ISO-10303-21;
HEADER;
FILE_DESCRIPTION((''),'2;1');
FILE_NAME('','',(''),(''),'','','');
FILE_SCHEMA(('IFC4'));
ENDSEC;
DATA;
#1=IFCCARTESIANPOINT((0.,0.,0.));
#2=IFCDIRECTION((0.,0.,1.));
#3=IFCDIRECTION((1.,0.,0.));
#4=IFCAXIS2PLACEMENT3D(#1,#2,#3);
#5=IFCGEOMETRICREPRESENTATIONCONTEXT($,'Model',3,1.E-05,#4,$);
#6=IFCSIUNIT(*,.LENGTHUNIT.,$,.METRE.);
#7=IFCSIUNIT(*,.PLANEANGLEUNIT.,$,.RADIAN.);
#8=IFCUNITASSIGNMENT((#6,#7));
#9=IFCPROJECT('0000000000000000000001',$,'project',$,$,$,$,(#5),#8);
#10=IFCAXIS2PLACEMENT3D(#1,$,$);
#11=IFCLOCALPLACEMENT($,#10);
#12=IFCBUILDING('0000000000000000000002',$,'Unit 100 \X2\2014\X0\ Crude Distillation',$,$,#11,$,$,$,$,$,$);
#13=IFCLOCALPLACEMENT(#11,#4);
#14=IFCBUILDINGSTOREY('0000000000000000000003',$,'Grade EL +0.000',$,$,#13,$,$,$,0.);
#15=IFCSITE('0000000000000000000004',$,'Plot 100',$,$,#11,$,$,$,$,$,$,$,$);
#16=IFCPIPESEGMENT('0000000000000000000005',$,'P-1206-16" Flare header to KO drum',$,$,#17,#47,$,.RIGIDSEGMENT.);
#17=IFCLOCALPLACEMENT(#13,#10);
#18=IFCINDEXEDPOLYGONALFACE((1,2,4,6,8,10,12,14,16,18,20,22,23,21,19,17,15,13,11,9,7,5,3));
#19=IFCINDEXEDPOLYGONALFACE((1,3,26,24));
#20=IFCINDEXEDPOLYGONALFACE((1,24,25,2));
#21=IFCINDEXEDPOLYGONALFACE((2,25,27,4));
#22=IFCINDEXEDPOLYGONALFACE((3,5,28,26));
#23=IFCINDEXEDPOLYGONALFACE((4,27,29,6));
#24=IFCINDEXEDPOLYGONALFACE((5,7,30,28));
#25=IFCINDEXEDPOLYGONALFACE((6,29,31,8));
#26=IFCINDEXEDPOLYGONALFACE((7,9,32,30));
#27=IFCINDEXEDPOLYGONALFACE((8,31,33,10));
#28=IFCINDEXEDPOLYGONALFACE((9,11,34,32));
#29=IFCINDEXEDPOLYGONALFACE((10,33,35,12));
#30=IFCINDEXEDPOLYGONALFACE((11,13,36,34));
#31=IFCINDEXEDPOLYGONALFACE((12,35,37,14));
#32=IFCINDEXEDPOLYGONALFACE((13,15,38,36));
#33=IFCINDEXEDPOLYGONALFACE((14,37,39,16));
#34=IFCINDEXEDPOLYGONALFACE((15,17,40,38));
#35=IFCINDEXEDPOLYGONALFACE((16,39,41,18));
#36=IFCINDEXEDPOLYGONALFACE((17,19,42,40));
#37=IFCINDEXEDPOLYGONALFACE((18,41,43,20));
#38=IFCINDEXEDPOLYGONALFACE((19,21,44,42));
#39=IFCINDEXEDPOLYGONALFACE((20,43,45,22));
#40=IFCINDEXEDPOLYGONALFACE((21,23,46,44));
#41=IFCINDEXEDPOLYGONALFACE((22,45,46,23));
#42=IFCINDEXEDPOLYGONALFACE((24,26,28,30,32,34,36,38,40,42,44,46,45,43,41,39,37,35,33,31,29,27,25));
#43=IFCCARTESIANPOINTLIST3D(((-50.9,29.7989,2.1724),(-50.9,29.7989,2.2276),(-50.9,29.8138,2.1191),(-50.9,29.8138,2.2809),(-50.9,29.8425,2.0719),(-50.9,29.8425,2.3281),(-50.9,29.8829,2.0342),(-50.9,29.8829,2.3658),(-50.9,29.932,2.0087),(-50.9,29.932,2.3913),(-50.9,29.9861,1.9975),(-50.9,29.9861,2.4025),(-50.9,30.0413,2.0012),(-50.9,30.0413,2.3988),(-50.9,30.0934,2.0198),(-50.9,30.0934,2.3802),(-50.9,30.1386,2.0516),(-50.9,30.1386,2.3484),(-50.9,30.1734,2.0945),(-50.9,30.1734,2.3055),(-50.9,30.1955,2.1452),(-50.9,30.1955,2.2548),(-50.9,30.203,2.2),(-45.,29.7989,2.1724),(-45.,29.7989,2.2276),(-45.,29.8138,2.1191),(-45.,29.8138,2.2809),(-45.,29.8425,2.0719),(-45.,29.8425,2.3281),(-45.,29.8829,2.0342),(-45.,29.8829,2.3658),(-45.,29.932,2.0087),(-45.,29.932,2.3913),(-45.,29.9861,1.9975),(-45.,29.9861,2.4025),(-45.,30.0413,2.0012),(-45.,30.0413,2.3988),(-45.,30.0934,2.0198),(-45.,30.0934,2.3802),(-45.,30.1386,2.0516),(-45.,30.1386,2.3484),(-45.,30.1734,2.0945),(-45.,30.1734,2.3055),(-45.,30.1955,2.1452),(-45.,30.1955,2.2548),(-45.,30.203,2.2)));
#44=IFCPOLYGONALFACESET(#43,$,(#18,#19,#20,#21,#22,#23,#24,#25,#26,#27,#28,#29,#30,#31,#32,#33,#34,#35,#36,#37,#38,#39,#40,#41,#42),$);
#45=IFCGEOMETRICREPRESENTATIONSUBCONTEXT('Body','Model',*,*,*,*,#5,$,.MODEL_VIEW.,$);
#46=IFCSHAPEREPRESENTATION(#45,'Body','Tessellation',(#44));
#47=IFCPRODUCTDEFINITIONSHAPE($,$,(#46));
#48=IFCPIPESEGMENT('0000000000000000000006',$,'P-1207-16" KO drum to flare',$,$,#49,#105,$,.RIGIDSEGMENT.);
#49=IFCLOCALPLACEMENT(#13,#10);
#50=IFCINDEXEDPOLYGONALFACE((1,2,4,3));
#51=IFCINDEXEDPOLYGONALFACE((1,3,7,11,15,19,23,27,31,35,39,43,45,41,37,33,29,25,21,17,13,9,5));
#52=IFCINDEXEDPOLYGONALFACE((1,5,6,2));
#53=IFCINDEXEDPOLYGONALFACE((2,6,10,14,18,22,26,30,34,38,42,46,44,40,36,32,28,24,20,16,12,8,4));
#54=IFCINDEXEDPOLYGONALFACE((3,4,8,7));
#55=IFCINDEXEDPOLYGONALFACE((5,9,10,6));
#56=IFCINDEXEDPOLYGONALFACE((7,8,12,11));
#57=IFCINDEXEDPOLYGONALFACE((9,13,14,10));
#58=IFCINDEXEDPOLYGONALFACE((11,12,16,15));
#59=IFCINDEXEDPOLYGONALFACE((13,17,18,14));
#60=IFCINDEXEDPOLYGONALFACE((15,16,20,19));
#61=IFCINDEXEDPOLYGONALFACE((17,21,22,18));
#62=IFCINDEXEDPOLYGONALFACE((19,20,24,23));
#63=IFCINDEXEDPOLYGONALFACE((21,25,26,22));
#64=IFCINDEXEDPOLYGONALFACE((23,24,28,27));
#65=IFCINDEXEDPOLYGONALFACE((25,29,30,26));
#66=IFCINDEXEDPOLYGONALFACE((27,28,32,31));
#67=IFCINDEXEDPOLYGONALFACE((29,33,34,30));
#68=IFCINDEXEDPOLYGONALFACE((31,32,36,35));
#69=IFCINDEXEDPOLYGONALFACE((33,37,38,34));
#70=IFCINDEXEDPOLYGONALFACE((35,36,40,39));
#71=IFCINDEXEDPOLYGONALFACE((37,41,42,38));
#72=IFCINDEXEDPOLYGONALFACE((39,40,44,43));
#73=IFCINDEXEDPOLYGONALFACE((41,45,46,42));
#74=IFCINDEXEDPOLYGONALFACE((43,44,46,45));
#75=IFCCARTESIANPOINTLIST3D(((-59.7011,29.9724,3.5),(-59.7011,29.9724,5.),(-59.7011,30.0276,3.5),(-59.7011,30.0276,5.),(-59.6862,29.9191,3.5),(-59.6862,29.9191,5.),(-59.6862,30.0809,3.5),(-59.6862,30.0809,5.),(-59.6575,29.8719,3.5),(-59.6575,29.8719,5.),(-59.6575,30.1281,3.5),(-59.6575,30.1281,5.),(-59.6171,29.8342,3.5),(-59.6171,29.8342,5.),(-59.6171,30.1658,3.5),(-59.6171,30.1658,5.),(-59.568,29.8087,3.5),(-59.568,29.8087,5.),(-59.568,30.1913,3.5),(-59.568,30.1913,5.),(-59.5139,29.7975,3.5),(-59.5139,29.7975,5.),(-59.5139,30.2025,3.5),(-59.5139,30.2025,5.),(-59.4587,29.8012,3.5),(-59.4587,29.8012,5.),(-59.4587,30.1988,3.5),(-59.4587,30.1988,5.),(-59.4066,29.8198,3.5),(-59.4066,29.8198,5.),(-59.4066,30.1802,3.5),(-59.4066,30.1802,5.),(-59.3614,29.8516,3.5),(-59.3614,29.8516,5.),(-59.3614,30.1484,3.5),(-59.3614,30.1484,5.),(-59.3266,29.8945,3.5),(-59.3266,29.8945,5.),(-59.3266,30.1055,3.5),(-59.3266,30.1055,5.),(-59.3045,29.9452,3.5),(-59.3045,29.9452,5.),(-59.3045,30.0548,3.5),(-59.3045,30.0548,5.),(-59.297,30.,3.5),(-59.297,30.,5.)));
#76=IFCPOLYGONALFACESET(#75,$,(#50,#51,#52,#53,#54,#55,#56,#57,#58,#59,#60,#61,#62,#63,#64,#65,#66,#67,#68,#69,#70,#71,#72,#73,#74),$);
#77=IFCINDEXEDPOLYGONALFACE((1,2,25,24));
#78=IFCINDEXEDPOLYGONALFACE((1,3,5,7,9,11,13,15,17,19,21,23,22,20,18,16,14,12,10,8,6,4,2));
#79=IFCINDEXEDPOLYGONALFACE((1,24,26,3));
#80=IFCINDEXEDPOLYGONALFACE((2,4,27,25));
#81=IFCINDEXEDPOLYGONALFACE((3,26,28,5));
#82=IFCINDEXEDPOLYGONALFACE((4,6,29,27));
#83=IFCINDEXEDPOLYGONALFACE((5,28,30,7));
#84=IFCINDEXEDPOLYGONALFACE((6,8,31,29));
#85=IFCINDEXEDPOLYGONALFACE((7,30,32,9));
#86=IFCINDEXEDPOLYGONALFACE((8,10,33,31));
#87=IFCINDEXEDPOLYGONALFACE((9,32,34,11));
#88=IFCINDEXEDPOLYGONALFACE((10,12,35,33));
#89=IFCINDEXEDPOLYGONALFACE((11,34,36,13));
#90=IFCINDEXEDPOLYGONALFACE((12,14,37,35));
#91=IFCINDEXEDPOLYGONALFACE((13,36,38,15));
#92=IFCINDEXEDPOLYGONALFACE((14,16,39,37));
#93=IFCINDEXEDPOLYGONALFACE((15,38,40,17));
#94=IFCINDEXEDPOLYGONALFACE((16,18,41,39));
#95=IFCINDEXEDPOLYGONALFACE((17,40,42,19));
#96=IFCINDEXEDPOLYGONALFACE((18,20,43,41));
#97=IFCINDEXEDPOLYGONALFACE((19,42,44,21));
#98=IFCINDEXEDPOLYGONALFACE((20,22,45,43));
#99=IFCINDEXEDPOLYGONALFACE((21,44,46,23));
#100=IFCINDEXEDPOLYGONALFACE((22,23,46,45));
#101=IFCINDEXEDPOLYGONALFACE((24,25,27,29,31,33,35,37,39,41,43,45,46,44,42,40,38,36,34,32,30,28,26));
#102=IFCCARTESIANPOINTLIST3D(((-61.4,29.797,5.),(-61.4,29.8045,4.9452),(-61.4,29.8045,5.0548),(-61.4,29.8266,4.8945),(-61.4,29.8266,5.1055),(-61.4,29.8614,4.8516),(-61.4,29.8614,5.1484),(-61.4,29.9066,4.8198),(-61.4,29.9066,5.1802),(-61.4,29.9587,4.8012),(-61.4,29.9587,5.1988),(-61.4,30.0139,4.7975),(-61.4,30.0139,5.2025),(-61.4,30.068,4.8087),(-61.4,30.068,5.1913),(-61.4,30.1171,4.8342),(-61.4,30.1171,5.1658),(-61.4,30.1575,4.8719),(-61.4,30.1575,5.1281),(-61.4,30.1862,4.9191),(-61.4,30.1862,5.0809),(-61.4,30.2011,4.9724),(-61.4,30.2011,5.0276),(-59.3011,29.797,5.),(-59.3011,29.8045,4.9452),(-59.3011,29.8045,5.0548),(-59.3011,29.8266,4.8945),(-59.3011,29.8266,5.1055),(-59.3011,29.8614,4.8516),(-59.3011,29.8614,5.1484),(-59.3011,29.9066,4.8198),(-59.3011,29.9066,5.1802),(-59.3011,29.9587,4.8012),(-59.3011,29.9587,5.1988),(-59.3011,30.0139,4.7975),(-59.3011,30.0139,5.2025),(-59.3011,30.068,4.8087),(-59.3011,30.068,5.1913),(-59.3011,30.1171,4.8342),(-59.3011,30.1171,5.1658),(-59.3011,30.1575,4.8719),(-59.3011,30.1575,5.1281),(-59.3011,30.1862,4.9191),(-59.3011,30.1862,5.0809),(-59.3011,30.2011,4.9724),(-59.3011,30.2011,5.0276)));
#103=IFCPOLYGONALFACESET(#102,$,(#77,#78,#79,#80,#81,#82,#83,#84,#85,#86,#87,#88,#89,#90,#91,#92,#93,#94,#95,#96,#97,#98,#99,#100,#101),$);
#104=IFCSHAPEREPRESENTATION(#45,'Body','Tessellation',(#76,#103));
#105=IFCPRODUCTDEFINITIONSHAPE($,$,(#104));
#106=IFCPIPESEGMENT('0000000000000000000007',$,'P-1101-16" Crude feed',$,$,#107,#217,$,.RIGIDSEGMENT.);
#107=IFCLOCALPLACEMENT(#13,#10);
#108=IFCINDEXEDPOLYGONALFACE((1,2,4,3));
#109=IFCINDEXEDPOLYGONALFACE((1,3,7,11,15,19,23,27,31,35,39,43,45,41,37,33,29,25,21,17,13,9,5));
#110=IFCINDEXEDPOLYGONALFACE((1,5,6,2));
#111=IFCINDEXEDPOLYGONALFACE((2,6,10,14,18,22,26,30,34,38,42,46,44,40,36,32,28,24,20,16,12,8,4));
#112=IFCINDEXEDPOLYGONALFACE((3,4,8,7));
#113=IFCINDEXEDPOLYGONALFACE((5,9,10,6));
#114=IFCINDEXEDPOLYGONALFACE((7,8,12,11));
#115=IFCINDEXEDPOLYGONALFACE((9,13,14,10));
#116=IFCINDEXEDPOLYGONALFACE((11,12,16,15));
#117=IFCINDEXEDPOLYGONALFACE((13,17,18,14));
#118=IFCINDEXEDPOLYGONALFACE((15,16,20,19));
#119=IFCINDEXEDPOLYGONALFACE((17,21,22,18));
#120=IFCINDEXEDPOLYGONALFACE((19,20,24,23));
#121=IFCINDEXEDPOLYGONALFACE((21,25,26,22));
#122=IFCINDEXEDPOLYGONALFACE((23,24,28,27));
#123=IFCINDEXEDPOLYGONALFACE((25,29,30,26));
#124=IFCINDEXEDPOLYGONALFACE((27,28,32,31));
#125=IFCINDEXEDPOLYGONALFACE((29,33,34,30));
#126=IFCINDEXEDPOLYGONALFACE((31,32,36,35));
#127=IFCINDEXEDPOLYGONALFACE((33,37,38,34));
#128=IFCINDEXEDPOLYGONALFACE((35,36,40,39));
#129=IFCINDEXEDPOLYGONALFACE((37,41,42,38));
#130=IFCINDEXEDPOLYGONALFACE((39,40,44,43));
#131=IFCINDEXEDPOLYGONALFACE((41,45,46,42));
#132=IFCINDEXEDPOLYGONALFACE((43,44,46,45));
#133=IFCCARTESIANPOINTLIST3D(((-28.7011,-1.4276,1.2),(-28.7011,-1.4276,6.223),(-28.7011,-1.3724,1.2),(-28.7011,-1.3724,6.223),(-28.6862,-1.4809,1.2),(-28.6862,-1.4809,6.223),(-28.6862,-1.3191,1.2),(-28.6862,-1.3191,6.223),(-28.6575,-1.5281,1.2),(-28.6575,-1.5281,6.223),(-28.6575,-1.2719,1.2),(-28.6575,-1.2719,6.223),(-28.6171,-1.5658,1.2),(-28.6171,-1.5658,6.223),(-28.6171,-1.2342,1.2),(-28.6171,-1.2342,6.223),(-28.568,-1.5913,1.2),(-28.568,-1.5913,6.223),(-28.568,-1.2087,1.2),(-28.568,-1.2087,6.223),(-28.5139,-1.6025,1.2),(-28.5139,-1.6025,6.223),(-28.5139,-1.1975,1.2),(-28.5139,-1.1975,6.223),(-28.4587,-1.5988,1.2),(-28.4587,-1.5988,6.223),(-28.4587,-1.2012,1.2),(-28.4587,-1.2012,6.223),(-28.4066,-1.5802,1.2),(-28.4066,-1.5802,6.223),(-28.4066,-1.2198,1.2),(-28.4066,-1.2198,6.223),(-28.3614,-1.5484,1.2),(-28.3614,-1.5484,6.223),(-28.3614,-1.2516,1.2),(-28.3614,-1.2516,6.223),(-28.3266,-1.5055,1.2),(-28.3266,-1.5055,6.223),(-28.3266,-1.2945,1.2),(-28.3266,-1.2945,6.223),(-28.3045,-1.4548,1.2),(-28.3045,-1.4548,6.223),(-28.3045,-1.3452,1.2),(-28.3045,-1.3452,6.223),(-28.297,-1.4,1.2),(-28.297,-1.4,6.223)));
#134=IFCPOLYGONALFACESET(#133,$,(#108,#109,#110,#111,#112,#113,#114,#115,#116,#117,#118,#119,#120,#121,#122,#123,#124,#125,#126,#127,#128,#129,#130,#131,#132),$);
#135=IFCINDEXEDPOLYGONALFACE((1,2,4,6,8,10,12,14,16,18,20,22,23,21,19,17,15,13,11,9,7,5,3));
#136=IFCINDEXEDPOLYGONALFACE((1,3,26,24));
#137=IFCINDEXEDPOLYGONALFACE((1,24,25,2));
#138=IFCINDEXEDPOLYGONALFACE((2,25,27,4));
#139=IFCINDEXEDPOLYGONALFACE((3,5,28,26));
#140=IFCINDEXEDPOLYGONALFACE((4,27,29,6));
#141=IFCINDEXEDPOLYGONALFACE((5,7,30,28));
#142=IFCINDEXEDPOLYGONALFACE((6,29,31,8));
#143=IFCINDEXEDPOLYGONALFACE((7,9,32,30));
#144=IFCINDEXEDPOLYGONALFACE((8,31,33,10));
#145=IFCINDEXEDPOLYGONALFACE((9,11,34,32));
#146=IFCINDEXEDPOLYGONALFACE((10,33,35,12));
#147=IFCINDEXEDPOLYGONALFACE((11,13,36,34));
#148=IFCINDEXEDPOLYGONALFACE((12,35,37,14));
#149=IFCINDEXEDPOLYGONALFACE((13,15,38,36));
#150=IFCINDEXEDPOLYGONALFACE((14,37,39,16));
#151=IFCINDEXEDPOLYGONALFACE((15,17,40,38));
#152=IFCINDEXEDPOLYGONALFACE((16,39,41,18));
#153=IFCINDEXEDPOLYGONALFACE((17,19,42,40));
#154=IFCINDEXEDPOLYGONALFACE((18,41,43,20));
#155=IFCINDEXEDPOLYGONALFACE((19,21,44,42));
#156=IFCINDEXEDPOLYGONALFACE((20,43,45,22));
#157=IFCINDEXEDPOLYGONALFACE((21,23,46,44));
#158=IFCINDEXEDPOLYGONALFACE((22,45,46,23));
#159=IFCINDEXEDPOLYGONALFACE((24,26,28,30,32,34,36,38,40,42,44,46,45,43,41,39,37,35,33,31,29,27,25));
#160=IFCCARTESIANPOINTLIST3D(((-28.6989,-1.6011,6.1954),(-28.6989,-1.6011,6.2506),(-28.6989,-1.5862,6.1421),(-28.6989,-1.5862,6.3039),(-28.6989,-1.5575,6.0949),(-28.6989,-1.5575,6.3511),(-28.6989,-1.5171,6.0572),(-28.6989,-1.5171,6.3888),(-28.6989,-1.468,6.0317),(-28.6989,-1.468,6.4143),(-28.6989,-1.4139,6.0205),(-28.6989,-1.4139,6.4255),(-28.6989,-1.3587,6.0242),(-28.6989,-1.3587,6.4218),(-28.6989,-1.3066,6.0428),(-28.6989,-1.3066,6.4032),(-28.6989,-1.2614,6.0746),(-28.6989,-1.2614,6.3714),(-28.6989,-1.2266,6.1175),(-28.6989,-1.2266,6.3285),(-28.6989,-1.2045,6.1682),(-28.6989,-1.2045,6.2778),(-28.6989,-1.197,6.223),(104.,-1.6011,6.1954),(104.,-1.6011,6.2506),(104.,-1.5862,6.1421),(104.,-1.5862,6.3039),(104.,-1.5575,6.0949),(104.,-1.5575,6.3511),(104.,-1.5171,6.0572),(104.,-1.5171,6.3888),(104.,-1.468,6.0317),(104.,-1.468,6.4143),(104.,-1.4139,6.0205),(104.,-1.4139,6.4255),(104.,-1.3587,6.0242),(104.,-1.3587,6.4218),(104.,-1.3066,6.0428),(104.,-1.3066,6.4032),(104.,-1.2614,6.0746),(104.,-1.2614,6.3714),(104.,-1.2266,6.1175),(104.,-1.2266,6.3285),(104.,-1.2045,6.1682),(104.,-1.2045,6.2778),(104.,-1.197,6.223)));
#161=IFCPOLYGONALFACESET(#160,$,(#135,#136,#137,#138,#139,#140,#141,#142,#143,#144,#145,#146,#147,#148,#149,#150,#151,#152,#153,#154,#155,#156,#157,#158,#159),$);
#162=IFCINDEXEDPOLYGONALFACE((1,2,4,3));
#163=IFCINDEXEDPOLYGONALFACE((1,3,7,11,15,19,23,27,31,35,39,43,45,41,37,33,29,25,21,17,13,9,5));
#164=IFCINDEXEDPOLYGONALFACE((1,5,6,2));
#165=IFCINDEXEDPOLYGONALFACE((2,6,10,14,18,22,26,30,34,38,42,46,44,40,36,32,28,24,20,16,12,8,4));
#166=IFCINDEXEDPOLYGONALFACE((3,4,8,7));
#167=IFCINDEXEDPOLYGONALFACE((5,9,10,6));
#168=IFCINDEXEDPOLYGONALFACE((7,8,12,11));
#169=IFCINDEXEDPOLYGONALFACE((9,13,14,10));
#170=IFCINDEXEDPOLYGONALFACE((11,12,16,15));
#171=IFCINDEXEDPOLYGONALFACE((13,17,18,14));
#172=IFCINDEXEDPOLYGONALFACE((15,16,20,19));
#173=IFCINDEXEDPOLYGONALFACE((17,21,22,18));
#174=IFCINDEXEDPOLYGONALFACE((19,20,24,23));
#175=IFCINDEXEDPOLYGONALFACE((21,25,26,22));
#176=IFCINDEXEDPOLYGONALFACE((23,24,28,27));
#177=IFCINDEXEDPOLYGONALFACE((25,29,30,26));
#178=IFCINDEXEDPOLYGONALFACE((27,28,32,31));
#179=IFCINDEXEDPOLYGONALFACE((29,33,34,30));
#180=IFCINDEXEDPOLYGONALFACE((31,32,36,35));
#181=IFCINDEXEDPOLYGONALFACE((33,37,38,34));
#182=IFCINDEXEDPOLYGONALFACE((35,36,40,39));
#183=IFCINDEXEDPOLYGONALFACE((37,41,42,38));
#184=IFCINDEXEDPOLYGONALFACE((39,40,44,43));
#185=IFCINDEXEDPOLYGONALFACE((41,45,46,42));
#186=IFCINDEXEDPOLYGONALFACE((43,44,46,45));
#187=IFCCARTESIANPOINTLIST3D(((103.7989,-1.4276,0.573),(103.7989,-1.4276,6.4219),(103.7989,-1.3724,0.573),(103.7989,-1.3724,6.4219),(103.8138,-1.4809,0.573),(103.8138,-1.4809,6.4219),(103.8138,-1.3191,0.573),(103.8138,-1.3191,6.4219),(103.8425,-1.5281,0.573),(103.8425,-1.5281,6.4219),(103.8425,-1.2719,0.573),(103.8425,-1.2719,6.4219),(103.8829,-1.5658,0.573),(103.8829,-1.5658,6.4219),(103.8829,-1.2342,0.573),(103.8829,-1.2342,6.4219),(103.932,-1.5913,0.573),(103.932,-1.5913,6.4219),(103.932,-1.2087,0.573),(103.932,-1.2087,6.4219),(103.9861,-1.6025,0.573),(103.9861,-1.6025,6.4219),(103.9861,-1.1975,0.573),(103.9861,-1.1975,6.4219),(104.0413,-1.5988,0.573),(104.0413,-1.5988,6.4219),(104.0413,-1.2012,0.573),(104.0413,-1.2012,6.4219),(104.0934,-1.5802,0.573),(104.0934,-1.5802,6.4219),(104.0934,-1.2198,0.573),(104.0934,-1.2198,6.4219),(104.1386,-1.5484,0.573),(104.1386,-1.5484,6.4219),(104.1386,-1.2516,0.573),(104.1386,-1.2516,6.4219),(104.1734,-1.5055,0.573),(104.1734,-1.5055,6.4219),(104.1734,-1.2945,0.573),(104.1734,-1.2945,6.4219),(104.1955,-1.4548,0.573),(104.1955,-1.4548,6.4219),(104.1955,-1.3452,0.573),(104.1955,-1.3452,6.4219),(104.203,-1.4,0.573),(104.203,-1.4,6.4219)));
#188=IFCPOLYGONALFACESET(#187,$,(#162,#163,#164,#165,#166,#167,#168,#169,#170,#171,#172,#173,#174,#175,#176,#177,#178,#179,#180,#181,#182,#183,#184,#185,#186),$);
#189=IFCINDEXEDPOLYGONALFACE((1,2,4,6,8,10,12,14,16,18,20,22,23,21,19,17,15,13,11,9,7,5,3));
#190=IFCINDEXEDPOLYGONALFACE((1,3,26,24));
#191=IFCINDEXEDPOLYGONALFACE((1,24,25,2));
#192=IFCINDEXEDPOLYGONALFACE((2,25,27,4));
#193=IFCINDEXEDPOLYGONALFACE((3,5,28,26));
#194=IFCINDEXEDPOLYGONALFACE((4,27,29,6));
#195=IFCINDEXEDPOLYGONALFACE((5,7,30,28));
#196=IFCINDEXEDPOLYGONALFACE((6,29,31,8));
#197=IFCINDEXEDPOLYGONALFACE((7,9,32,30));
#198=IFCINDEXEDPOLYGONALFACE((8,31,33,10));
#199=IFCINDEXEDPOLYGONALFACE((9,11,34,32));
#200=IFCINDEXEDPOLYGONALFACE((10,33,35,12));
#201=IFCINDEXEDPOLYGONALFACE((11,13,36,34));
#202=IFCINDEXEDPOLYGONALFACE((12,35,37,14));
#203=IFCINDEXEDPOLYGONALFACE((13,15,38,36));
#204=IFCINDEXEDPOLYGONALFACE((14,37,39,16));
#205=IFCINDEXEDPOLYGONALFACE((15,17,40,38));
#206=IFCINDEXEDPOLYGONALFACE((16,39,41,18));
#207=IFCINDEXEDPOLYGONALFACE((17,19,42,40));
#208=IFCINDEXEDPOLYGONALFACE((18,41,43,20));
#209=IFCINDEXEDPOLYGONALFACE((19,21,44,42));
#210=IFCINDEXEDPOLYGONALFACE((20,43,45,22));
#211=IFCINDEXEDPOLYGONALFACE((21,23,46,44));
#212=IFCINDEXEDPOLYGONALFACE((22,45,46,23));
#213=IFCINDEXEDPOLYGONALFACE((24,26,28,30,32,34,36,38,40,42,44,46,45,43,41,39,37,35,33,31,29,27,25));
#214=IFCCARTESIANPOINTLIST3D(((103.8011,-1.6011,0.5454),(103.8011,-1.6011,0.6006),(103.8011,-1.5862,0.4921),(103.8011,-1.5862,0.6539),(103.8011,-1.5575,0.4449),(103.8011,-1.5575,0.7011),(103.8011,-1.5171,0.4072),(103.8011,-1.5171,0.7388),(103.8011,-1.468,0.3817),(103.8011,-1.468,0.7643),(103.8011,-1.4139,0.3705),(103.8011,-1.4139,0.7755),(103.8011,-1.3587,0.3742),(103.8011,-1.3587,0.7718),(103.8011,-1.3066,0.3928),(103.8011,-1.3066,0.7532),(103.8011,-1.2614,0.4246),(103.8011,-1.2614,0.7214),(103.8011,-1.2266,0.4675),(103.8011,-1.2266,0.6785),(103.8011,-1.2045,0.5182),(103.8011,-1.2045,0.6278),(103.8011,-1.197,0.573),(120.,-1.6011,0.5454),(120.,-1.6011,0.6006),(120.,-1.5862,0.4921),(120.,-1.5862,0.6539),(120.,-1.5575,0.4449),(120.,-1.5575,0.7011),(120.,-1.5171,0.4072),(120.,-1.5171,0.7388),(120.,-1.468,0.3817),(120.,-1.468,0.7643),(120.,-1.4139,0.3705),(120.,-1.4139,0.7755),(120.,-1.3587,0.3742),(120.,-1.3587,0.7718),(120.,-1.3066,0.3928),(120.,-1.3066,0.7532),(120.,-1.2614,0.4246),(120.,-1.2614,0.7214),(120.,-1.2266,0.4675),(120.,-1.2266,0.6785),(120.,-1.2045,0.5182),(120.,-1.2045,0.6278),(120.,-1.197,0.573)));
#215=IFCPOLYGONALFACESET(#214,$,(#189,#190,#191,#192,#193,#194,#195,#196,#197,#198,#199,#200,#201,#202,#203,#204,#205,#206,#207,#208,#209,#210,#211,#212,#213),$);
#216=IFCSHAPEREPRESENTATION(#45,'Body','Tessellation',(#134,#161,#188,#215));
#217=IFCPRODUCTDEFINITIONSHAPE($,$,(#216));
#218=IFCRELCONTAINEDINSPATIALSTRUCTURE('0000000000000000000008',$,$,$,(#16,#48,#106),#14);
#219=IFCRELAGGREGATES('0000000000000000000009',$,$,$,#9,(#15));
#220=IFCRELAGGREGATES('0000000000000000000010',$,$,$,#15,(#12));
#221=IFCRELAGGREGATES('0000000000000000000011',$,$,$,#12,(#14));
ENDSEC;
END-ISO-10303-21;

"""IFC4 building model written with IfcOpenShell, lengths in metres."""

from ifc_helpers import new_model, si_unit, frame, origin, origin_with_axes, origin_2d, place, context, subcontext, project, spatial, circle, extrude, element, save


model = new_model("IFC4")

# Units and contexts
model_context = context("Model", 3, precision=1e-05, world=origin_with_axes())
body_context = subcontext(model_context, "Body", "Model", "MODEL_VIEW")
ifc_project = project(units=[si_unit("LENGTHUNIT", "METRE"), si_unit("PLANEANGLEUNIT", "RADIAN")], contexts=[model_context])

# Site, building, storey
placement = place(None, origin())
site = spatial("IfcSite", under=ifc_project, at=placement, Name="Plot 100")
building = spatial("IfcBuilding", under=site, at=placement, Name="Unit 100 — Crude Distillation")
storey_placement = place(placement, origin_with_axes())
storey = spatial("IfcBuildingStorey", under=building, at=storey_placement, Name="Grade EL +0.000", Elevation=0.0)

# Pipe segments
pipe_segment_1_placement = place(storey_placement, origin_with_axes())
element("IfcPipeSegment", 1, at=pipe_segment_1_placement, inside=storey, Name="P-1206-16\" Flare header to KO drum", PredefinedType="RIGIDSEGMENT", context=body_context, shape_type="SweptSolid", body=[
    extrude(circle(Radius=0.203, at=origin_2d()), frame((-50.9, 30.0, 2.2), z_axis=(1.0, 0.0, 0.0), x_axis=(0.0, 1.0, 0.0)), (0.0, 0.0, 1.0), 5.9),
])
pipe_segment_2_placement = place(storey_placement, origin_with_axes())
element("IfcPipeSegment", 2, at=pipe_segment_2_placement, inside=storey, Name="P-1207-16\" KO drum to flare", PredefinedType="RIGIDSEGMENT", context=body_context, shape_type="SweptSolid", body=[
    extrude(circle(Radius=0.203, at=origin_2d()), frame((-59.5, 30.0, 3.5), z_axis=(0.0, 0.0, 1.0), x_axis=(1.0, 0.0, 0.0)), (0.0, 0.0, 1.0), 1.5),
    extrude(circle(Radius=0.203, at=origin_2d()), frame((-59.3011, 30.0, 5.0), z_axis=(-1.0, 0.0, 0.0), x_axis=(0.0, -1.0, 0.0)), (0.0, 0.0, 1.0), 2.0989),
])
pipe_segment_3_placement = place(storey_placement, origin_with_axes())
element("IfcPipeSegment", 3, at=pipe_segment_3_placement, inside=storey, Name="P-1101-16\" Crude feed", PredefinedType="RIGIDSEGMENT", context=body_context, shape_type="SweptSolid", body=[
    extrude(circle(Radius=0.203, at=origin_2d()), frame((-28.5, -1.4, 1.2), z_axis=(0.0, 0.0, 1.0), x_axis=(1.0, 0.0, 0.0)), (0.0, 0.0, 1.0), 5.023),
    extrude(circle(Radius=0.203, at=origin_2d()), frame((-28.6989, -1.4, 6.223), z_axis=(1.0, 0.0, 0.0), x_axis=(0.0, 1.0, 0.0)), (0.0, 0.0, 1.0), 132.6989),
    extrude(circle(Radius=0.203, at=origin_2d()), frame((104.0, -1.4, 6.4219), z_axis=(0.0, 0.0, -1.0), x_axis=(1.0, 0.0, 0.0)), (0.0, 0.0, 1.0), 5.8489),
    extrude(circle(Radius=0.203, at=origin_2d()), frame((103.8011, -1.4, 0.573), z_axis=(1.0, 0.0, 0.0), x_axis=(0.0, 1.0, 0.0)), (0.0, 0.0, 1.0), 16.1989),
])

save(model, "model.ifc")
